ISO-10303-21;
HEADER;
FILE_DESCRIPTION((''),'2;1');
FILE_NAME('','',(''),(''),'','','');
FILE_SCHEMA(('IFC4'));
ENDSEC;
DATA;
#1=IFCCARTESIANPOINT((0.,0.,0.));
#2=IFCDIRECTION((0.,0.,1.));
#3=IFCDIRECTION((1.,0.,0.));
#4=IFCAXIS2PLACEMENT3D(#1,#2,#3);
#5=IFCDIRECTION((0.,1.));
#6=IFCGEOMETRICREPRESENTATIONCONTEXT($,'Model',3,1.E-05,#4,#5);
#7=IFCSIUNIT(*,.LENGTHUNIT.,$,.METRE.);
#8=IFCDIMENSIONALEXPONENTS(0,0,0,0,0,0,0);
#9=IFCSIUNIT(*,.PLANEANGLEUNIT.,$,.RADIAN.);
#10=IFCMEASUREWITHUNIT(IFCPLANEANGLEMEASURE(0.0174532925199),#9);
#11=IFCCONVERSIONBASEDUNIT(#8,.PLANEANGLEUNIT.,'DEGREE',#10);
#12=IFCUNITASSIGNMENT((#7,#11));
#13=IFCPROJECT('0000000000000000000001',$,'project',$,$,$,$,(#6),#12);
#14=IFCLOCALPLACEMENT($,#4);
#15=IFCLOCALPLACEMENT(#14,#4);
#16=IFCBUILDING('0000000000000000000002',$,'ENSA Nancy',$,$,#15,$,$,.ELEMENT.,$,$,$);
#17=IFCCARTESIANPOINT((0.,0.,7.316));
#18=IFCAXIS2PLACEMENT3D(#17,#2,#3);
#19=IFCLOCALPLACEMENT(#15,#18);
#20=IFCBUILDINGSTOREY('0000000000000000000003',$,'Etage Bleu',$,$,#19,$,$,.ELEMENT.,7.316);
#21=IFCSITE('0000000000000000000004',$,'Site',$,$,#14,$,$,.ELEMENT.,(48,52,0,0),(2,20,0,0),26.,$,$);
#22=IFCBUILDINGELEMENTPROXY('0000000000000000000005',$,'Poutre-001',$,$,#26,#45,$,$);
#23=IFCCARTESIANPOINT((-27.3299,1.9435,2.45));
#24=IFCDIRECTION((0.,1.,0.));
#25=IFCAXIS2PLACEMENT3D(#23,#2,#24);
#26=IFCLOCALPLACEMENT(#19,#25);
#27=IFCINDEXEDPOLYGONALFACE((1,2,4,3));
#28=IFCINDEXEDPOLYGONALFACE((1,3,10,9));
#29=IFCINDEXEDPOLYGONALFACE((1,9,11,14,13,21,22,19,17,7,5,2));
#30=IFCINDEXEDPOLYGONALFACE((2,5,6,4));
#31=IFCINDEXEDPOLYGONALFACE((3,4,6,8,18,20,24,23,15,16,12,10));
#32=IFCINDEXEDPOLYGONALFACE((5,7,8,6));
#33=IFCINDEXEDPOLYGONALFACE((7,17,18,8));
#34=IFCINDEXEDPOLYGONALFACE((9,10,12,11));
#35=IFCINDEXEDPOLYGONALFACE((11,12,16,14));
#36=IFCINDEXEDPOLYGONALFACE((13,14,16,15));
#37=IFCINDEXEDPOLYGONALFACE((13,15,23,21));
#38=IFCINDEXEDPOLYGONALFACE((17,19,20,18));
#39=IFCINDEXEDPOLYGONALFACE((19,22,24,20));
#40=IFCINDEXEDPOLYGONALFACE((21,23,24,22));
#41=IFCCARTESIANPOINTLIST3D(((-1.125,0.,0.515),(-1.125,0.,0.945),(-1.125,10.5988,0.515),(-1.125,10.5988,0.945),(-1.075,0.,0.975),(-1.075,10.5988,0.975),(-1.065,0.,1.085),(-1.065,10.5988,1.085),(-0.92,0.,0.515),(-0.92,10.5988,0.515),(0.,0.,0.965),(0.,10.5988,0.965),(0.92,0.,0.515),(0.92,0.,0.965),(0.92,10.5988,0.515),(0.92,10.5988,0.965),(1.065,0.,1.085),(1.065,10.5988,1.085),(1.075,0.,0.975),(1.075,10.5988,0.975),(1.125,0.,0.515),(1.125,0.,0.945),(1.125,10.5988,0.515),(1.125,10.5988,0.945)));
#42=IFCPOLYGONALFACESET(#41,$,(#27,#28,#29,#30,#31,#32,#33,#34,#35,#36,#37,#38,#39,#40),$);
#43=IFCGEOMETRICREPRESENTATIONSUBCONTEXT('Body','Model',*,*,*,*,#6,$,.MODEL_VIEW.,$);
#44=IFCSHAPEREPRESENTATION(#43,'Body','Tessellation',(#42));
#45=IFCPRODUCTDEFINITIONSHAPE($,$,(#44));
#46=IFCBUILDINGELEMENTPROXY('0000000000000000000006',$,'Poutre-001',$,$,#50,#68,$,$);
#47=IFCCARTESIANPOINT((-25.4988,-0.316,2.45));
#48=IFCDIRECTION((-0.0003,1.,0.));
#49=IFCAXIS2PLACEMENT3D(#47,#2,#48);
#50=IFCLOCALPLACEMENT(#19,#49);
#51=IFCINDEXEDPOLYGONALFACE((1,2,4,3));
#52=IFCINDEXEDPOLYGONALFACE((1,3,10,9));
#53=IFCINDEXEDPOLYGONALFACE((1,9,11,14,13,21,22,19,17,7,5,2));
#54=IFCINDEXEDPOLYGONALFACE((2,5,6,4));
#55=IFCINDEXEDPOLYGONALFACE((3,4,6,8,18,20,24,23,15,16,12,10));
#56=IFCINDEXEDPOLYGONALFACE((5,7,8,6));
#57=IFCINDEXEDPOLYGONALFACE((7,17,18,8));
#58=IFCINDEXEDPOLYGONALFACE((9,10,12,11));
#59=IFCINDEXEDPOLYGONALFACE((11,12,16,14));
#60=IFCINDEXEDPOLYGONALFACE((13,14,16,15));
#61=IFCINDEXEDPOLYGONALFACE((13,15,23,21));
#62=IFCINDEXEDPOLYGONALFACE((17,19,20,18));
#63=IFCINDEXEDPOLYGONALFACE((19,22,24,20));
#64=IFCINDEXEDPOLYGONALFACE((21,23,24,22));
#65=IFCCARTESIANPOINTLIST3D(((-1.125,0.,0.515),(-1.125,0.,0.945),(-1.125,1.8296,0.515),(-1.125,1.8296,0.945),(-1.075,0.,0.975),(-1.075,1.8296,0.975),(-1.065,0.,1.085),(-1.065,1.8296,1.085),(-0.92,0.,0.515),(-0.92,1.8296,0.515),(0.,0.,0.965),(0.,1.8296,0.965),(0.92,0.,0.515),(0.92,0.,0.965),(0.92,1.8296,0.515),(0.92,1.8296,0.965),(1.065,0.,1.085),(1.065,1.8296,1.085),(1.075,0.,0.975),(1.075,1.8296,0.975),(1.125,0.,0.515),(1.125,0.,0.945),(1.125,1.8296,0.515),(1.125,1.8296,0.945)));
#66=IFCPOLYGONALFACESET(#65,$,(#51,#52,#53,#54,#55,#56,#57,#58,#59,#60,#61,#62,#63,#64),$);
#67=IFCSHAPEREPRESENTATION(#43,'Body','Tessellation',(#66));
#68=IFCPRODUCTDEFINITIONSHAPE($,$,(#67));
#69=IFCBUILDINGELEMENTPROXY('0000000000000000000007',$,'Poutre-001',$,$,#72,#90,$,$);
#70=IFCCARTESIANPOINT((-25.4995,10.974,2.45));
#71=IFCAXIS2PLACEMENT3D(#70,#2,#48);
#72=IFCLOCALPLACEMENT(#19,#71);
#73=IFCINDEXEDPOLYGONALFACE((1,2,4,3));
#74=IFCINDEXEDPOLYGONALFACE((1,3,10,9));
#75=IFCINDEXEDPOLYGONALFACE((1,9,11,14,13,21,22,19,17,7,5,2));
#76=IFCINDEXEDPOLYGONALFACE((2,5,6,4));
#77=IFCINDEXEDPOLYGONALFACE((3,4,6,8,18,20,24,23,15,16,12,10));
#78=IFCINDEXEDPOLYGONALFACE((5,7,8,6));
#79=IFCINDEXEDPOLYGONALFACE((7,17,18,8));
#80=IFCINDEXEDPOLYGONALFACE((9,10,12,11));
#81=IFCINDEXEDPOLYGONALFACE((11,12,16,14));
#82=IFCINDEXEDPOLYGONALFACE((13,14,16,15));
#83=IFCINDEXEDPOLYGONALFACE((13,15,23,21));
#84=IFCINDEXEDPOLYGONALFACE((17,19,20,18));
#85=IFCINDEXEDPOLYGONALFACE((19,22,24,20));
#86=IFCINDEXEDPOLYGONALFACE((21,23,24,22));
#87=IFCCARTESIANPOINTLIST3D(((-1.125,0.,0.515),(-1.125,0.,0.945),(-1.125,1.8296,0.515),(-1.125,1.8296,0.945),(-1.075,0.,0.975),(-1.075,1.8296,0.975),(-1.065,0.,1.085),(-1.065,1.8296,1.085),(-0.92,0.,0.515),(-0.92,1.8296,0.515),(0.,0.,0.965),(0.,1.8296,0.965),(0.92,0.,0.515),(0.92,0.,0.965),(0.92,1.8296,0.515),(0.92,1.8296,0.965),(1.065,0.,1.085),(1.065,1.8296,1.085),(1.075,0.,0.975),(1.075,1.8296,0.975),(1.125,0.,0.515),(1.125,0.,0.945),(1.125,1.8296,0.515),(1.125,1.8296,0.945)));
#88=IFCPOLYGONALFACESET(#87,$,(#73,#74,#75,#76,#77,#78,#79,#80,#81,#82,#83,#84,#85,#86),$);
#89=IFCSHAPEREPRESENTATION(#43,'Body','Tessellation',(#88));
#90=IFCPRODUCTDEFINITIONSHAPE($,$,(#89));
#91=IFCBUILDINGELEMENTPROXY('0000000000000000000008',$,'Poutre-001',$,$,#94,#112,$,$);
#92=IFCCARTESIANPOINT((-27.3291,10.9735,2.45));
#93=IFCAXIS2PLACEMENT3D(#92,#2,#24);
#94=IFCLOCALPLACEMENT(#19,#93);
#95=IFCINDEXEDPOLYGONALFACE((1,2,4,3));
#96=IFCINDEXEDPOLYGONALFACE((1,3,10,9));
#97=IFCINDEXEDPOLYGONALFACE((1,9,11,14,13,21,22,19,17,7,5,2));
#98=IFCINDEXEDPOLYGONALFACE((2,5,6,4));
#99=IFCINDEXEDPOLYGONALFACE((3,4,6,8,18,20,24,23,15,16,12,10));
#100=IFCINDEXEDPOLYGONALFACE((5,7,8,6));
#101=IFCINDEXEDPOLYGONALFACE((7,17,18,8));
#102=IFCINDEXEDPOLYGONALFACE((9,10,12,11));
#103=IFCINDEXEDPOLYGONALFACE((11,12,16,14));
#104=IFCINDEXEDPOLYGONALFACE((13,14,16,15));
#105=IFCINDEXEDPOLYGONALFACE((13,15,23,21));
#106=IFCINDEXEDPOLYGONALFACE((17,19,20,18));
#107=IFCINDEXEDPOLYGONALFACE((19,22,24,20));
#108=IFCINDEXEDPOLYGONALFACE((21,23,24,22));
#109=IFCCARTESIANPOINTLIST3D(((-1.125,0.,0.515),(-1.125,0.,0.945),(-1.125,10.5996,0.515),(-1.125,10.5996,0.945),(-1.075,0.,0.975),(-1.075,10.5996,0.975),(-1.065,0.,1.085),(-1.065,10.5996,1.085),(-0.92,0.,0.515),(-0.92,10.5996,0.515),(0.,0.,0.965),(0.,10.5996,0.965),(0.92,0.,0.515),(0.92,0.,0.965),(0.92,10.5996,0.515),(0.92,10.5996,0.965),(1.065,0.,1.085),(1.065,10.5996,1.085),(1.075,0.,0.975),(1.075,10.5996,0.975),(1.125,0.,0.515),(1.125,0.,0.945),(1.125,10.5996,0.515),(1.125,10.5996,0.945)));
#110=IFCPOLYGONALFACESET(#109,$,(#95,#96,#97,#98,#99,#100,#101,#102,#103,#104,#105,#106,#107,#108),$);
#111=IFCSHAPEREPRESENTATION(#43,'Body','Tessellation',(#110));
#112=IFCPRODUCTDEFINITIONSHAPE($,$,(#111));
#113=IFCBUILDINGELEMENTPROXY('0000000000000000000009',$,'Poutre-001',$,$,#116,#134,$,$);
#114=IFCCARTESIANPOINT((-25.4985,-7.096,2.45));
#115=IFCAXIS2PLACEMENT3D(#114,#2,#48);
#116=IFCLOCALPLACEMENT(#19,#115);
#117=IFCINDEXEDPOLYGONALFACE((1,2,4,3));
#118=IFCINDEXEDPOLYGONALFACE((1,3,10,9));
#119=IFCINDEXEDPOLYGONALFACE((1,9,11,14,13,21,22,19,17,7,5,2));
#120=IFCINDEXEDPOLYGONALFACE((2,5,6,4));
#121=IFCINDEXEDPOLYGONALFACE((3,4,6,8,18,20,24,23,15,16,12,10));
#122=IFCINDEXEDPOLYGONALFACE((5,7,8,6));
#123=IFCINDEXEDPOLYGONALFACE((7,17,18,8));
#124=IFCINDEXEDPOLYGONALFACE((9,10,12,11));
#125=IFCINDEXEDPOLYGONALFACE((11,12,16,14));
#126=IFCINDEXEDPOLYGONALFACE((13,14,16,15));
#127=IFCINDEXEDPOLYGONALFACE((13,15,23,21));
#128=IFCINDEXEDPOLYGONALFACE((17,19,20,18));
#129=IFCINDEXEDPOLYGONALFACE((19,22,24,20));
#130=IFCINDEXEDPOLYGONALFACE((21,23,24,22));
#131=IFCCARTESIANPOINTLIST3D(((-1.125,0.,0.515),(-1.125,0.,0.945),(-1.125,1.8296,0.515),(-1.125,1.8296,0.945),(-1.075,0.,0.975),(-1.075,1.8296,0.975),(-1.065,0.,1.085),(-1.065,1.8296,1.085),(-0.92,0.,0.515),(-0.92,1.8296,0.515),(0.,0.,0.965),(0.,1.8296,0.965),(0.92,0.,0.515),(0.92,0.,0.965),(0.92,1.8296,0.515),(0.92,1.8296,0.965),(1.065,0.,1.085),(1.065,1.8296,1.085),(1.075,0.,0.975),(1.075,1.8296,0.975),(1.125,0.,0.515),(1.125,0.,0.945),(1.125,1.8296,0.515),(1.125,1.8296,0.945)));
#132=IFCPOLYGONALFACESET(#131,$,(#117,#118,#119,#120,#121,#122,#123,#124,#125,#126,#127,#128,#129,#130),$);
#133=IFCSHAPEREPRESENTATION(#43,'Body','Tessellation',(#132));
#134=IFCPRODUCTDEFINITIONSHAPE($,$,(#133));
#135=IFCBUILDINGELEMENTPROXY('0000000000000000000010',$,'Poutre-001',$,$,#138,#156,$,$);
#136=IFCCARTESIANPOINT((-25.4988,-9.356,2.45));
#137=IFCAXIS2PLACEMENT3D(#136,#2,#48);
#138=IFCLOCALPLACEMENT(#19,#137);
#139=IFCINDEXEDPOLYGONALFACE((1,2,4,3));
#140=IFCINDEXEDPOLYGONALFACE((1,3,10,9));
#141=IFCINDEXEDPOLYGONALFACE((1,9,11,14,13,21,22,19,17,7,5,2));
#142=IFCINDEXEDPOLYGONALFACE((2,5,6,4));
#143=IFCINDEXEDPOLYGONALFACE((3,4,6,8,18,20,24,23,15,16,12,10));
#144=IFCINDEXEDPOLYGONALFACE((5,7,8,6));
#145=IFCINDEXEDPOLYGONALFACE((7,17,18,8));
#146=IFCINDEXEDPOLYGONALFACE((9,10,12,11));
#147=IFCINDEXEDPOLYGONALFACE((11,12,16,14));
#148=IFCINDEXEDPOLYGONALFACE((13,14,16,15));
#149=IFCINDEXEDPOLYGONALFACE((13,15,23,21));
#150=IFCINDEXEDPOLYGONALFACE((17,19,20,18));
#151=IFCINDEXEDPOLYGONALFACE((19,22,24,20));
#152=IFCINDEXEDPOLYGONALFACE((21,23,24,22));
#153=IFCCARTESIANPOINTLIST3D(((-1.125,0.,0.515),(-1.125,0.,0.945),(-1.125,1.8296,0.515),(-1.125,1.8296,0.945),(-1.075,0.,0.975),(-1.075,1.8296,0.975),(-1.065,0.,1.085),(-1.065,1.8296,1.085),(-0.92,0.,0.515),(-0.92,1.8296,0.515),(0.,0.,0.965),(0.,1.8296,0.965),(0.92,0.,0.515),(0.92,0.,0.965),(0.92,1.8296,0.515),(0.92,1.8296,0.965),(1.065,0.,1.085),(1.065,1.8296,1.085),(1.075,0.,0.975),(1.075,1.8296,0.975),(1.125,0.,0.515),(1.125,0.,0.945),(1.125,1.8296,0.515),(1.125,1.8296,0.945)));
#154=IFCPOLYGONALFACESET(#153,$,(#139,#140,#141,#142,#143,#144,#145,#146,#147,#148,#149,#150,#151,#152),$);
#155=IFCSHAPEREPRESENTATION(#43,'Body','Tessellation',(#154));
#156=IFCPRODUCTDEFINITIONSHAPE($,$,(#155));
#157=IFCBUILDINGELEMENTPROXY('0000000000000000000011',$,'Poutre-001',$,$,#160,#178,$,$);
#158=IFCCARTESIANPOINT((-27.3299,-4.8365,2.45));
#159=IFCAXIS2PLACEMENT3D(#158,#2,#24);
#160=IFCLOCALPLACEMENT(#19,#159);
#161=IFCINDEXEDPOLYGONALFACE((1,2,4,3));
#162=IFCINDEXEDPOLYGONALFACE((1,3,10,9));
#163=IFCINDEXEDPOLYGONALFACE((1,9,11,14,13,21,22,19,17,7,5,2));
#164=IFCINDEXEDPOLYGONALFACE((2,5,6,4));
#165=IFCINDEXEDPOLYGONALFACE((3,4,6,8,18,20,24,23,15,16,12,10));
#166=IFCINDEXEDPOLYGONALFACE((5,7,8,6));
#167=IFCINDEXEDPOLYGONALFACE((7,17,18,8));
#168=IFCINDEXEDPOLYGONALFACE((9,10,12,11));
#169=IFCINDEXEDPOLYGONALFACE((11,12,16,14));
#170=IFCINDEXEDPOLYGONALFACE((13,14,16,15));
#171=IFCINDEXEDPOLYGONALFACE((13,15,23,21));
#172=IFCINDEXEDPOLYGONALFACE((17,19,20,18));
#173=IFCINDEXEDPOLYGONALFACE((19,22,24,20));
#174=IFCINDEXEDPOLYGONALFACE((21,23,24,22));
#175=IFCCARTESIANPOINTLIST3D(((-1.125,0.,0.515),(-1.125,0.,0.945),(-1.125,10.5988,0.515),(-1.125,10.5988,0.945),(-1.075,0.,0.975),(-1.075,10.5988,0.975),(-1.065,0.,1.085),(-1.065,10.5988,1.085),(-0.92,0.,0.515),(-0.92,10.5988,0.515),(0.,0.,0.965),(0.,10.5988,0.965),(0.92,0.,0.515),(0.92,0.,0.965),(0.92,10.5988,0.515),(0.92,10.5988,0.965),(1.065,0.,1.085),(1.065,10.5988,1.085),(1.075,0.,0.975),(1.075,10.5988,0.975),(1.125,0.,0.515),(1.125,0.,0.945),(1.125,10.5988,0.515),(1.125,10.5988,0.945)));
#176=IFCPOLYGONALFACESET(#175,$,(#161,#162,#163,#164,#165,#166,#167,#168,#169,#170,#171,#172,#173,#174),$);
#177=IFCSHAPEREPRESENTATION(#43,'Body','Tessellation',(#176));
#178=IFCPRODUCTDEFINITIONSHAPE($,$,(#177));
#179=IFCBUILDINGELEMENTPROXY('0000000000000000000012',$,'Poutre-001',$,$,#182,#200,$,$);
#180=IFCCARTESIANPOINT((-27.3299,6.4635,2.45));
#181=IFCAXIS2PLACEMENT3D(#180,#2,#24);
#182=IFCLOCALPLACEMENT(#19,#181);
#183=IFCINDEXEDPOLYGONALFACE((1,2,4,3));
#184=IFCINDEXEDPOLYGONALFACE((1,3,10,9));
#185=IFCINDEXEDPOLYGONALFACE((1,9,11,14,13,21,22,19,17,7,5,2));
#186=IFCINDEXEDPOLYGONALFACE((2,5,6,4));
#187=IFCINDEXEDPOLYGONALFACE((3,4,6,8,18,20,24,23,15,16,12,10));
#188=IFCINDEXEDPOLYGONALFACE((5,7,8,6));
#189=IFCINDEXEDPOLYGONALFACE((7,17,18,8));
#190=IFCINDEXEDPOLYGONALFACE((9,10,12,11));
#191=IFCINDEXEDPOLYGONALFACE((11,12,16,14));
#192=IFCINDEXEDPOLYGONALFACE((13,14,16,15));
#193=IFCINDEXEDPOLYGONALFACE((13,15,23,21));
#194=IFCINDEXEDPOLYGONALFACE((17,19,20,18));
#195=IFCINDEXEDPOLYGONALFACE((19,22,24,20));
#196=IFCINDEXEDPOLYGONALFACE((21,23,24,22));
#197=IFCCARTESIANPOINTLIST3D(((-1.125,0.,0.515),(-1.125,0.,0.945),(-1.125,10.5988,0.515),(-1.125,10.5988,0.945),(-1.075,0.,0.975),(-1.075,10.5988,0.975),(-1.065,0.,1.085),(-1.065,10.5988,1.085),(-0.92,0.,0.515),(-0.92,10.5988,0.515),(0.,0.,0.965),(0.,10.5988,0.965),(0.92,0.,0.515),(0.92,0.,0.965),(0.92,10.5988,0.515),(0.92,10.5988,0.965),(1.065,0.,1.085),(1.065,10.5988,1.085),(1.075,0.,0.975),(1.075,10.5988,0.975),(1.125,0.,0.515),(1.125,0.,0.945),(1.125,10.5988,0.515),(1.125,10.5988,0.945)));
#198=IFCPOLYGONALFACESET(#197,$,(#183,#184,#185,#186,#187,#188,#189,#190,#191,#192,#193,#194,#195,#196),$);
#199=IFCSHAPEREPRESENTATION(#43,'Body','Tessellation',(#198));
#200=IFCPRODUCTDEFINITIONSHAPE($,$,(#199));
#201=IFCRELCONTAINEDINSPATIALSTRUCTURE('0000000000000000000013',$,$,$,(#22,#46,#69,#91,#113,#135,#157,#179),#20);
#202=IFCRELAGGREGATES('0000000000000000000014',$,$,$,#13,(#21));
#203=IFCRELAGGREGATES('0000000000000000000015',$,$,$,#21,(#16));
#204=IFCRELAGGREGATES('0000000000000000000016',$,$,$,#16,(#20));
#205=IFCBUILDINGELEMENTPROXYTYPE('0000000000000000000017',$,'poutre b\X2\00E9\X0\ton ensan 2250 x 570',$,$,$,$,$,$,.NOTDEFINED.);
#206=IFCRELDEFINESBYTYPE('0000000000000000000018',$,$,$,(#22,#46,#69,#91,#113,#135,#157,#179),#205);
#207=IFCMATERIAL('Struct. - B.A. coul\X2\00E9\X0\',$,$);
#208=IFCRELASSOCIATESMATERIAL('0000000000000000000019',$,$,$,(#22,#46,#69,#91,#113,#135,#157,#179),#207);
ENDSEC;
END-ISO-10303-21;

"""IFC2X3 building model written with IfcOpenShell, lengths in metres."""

from ifc_helpers import new_model, entity, si_unit, converted_unit, direction, frame, origin_with_axes, place, context, subcontext, project, spatial, polyline, outline, extrude, material, type_object, element, save


model = new_model("IFC2X3")

# Units and contexts
model_context = context("Model", 3, precision=1e-05, world=origin_with_axes(), true_north=direction((0.0, 1.0)))
body_context = subcontext(model_context, "Body", "Model", "MODEL_VIEW")
ifc_project = project(units=[si_unit("LENGTHUNIT", "METRE"), converted_unit("PLANEANGLEUNIT", "DEGREE", entity("IfcPlaneAngleMeasure", 0.0174532925199), si_unit("PLANEANGLEUNIT", "RADIAN"), dimensions=[0, 0, 0, 0, 0, 0, 0])], contexts=[model_context])

# Site, building, storey
site_placement = place(None, origin_with_axes())
site = spatial("IfcSite", under=ifc_project, at=site_placement, Name="Site", CompositionType="ELEMENT", RefLatitude=(48, 52, 0, 0), RefLongitude=(2, 20, 0, 0), RefElevation=26.0)
building_placement = place(site_placement, origin_with_axes())
building = spatial("IfcBuilding", under=site, at=building_placement, Name="ENSA Nancy", CompositionType="ELEMENT")
storey_placement = place(building_placement, frame((0.0, 0.0, 7.316), z_axis=(0.0, 0.0, 1.0), x_axis=(1.0, 0.0, 0.0)))
storey = spatial("IfcBuildingStorey", under=building, at=storey_placement, Name="Etage Bleu", CompositionType="ELEMENT", Elevation=7.316)

# Building element proxies
ifc_material_1 = material(Name="Struct. - B.A. coulé")
building_element_proxy_type_1 = type_object("IfcBuildingElementProxyType", Name="poutre béton ensan 2250 x 570", PredefinedType="NOTDEFINED")
proxy_1_placement = place(storey_placement, frame((-27.3299, 1.9435, 2.45), z_axis=(0.0, 0.0, 1.0), x_axis=(0.0, 1.0, 0.0)))
element("IfcBuildingElementProxy", 1, at=proxy_1_placement, inside=storey, type_object=building_element_proxy_type_1, material=ifc_material_1, Name="Poutre-001", context=body_context, shape_type="SweptSolid", body=[
    extrude(outline(polyline([(-1.065, 1.085), (-1.075, 0.975), (-1.125, 0.945), (-1.125, 0.515), (-0.92, 0.515), (0.0, 0.965), (0.92, 0.965), (0.92, 0.515), (1.125, 0.515), (1.125, 0.945), (1.075, 0.975), (1.065, 1.085), (-1.065, 1.085)])), frame((0.0, 10.5988, 0.0), z_axis=(0.0, -1.0, 0.0), x_axis=(1.0, 0.0, 0.0)), (0.0, 0.0, 1.0), 10.5988),
])
for number, where, z_axis, x_axis, name in (
    (2, (-25.4988, -0.316, 2.45), (0.0, 0.0, 1.0), (-0.0003, 1.0, 0.0), "Poutre-001"),
    (3, (-25.4995, 10.974, 2.45), (0.0, 0.0, 1.0), (-0.0003, 1.0, 0.0), "Poutre-001"),
):
    element("IfcBuildingElementProxy", number, at=place(storey_placement, frame(where, z_axis=z_axis, x_axis=x_axis)), inside=storey, type_object=building_element_proxy_type_1, material=ifc_material_1, Name=name, context=body_context, shape_type="SweptSolid", body=[
        extrude(outline(polyline([(-1.065, 1.085), (-1.075, 0.975), (-1.125, 0.945), (-1.125, 0.515), (-0.92, 0.515), (0.0, 0.965), (0.92, 0.965), (0.92, 0.515), (1.125, 0.515), (1.125, 0.945), (1.075, 0.975), (1.065, 1.085), (-1.065, 1.085)])), frame((0.0, 1.8296, 0.0), z_axis=(0.0, -1.0, 0.0), x_axis=(1.0, 0.0, 0.0)), (0.0, 0.0, 1.0), 1.8296),
    ])
proxy_2_placement = place(storey_placement, frame((-27.3291, 10.9735, 2.45), z_axis=(0.0, 0.0, 1.0), x_axis=(0.0, 1.0, 0.0)))
element("IfcBuildingElementProxy", 4, at=proxy_2_placement, inside=storey, type_object=building_element_proxy_type_1, material=ifc_material_1, Name="Poutre-001", context=body_context, shape_type="SweptSolid", body=[
    extrude(outline(polyline([(-1.065, 1.085), (-1.075, 0.975), (-1.125, 0.945), (-1.125, 0.515), (-0.92, 0.515), (0.0, 0.965), (0.92, 0.965), (0.92, 0.515), (1.125, 0.515), (1.125, 0.945), (1.075, 0.975), (1.065, 1.085), (-1.065, 1.085)])), frame((0.0, 10.5996, 0.0), z_axis=(0.0, -1.0, 0.0), x_axis=(1.0, 0.0, 0.0)), (0.0, 0.0, 1.0), 10.5996),
])
for number, where, z_axis, x_axis, name in (
    (5, (-25.4985, -7.096, 2.45), (0.0, 0.0, 1.0), (-0.0003, 1.0, 0.0), "Poutre-001"),
    (6, (-25.4988, -9.356, 2.45), (0.0, 0.0, 1.0), (-0.0003, 1.0, 0.0), "Poutre-001"),
):
    element("IfcBuildingElementProxy", number, at=place(storey_placement, frame(where, z_axis=z_axis, x_axis=x_axis)), inside=storey, type_object=building_element_proxy_type_1, material=ifc_material_1, Name=name, context=body_context, shape_type="SweptSolid", body=[
        extrude(outline(polyline([(-1.065, 1.085), (-1.075, 0.975), (-1.125, 0.945), (-1.125, 0.515), (-0.92, 0.515), (0.0, 0.965), (0.92, 0.965), (0.92, 0.515), (1.125, 0.515), (1.125, 0.945), (1.075, 0.975), (1.065, 1.085), (-1.065, 1.085)])), frame((0.0, 1.8296, 0.0), z_axis=(0.0, -1.0, 0.0), x_axis=(1.0, 0.0, 0.0)), (0.0, 0.0, 1.0), 1.8296),
    ])
for number, where, z_axis, x_axis, name in (
    (7, (-27.3299, -4.8365, 2.45), (0.0, 0.0, 1.0), (0.0, 1.0, 0.0), "Poutre-001"),
    (8, (-27.3299, 6.4635, 2.45), (0.0, 0.0, 1.0), (0.0, 1.0, 0.0), "Poutre-001"),
):
    element("IfcBuildingElementProxy", number, at=place(storey_placement, frame(where, z_axis=z_axis, x_axis=x_axis)), inside=storey, type_object=building_element_proxy_type_1, material=ifc_material_1, Name=name, context=body_context, shape_type="SweptSolid", body=[
        extrude(outline(polyline([(-1.065, 1.085), (-1.075, 0.975), (-1.125, 0.945), (-1.125, 0.515), (-0.92, 0.515), (0.0, 0.965), (0.92, 0.965), (0.92, 0.515), (1.125, 0.515), (1.125, 0.945), (1.075, 0.975), (1.065, 1.085), (-1.065, 1.085)])), frame((0.0, 10.5988, 0.0), z_axis=(0.0, -1.0, 0.0), x_axis=(1.0, 0.0, 0.0)), (0.0, 0.0, 1.0), 10.5988),
    ])

save(model, "model.ifc")
